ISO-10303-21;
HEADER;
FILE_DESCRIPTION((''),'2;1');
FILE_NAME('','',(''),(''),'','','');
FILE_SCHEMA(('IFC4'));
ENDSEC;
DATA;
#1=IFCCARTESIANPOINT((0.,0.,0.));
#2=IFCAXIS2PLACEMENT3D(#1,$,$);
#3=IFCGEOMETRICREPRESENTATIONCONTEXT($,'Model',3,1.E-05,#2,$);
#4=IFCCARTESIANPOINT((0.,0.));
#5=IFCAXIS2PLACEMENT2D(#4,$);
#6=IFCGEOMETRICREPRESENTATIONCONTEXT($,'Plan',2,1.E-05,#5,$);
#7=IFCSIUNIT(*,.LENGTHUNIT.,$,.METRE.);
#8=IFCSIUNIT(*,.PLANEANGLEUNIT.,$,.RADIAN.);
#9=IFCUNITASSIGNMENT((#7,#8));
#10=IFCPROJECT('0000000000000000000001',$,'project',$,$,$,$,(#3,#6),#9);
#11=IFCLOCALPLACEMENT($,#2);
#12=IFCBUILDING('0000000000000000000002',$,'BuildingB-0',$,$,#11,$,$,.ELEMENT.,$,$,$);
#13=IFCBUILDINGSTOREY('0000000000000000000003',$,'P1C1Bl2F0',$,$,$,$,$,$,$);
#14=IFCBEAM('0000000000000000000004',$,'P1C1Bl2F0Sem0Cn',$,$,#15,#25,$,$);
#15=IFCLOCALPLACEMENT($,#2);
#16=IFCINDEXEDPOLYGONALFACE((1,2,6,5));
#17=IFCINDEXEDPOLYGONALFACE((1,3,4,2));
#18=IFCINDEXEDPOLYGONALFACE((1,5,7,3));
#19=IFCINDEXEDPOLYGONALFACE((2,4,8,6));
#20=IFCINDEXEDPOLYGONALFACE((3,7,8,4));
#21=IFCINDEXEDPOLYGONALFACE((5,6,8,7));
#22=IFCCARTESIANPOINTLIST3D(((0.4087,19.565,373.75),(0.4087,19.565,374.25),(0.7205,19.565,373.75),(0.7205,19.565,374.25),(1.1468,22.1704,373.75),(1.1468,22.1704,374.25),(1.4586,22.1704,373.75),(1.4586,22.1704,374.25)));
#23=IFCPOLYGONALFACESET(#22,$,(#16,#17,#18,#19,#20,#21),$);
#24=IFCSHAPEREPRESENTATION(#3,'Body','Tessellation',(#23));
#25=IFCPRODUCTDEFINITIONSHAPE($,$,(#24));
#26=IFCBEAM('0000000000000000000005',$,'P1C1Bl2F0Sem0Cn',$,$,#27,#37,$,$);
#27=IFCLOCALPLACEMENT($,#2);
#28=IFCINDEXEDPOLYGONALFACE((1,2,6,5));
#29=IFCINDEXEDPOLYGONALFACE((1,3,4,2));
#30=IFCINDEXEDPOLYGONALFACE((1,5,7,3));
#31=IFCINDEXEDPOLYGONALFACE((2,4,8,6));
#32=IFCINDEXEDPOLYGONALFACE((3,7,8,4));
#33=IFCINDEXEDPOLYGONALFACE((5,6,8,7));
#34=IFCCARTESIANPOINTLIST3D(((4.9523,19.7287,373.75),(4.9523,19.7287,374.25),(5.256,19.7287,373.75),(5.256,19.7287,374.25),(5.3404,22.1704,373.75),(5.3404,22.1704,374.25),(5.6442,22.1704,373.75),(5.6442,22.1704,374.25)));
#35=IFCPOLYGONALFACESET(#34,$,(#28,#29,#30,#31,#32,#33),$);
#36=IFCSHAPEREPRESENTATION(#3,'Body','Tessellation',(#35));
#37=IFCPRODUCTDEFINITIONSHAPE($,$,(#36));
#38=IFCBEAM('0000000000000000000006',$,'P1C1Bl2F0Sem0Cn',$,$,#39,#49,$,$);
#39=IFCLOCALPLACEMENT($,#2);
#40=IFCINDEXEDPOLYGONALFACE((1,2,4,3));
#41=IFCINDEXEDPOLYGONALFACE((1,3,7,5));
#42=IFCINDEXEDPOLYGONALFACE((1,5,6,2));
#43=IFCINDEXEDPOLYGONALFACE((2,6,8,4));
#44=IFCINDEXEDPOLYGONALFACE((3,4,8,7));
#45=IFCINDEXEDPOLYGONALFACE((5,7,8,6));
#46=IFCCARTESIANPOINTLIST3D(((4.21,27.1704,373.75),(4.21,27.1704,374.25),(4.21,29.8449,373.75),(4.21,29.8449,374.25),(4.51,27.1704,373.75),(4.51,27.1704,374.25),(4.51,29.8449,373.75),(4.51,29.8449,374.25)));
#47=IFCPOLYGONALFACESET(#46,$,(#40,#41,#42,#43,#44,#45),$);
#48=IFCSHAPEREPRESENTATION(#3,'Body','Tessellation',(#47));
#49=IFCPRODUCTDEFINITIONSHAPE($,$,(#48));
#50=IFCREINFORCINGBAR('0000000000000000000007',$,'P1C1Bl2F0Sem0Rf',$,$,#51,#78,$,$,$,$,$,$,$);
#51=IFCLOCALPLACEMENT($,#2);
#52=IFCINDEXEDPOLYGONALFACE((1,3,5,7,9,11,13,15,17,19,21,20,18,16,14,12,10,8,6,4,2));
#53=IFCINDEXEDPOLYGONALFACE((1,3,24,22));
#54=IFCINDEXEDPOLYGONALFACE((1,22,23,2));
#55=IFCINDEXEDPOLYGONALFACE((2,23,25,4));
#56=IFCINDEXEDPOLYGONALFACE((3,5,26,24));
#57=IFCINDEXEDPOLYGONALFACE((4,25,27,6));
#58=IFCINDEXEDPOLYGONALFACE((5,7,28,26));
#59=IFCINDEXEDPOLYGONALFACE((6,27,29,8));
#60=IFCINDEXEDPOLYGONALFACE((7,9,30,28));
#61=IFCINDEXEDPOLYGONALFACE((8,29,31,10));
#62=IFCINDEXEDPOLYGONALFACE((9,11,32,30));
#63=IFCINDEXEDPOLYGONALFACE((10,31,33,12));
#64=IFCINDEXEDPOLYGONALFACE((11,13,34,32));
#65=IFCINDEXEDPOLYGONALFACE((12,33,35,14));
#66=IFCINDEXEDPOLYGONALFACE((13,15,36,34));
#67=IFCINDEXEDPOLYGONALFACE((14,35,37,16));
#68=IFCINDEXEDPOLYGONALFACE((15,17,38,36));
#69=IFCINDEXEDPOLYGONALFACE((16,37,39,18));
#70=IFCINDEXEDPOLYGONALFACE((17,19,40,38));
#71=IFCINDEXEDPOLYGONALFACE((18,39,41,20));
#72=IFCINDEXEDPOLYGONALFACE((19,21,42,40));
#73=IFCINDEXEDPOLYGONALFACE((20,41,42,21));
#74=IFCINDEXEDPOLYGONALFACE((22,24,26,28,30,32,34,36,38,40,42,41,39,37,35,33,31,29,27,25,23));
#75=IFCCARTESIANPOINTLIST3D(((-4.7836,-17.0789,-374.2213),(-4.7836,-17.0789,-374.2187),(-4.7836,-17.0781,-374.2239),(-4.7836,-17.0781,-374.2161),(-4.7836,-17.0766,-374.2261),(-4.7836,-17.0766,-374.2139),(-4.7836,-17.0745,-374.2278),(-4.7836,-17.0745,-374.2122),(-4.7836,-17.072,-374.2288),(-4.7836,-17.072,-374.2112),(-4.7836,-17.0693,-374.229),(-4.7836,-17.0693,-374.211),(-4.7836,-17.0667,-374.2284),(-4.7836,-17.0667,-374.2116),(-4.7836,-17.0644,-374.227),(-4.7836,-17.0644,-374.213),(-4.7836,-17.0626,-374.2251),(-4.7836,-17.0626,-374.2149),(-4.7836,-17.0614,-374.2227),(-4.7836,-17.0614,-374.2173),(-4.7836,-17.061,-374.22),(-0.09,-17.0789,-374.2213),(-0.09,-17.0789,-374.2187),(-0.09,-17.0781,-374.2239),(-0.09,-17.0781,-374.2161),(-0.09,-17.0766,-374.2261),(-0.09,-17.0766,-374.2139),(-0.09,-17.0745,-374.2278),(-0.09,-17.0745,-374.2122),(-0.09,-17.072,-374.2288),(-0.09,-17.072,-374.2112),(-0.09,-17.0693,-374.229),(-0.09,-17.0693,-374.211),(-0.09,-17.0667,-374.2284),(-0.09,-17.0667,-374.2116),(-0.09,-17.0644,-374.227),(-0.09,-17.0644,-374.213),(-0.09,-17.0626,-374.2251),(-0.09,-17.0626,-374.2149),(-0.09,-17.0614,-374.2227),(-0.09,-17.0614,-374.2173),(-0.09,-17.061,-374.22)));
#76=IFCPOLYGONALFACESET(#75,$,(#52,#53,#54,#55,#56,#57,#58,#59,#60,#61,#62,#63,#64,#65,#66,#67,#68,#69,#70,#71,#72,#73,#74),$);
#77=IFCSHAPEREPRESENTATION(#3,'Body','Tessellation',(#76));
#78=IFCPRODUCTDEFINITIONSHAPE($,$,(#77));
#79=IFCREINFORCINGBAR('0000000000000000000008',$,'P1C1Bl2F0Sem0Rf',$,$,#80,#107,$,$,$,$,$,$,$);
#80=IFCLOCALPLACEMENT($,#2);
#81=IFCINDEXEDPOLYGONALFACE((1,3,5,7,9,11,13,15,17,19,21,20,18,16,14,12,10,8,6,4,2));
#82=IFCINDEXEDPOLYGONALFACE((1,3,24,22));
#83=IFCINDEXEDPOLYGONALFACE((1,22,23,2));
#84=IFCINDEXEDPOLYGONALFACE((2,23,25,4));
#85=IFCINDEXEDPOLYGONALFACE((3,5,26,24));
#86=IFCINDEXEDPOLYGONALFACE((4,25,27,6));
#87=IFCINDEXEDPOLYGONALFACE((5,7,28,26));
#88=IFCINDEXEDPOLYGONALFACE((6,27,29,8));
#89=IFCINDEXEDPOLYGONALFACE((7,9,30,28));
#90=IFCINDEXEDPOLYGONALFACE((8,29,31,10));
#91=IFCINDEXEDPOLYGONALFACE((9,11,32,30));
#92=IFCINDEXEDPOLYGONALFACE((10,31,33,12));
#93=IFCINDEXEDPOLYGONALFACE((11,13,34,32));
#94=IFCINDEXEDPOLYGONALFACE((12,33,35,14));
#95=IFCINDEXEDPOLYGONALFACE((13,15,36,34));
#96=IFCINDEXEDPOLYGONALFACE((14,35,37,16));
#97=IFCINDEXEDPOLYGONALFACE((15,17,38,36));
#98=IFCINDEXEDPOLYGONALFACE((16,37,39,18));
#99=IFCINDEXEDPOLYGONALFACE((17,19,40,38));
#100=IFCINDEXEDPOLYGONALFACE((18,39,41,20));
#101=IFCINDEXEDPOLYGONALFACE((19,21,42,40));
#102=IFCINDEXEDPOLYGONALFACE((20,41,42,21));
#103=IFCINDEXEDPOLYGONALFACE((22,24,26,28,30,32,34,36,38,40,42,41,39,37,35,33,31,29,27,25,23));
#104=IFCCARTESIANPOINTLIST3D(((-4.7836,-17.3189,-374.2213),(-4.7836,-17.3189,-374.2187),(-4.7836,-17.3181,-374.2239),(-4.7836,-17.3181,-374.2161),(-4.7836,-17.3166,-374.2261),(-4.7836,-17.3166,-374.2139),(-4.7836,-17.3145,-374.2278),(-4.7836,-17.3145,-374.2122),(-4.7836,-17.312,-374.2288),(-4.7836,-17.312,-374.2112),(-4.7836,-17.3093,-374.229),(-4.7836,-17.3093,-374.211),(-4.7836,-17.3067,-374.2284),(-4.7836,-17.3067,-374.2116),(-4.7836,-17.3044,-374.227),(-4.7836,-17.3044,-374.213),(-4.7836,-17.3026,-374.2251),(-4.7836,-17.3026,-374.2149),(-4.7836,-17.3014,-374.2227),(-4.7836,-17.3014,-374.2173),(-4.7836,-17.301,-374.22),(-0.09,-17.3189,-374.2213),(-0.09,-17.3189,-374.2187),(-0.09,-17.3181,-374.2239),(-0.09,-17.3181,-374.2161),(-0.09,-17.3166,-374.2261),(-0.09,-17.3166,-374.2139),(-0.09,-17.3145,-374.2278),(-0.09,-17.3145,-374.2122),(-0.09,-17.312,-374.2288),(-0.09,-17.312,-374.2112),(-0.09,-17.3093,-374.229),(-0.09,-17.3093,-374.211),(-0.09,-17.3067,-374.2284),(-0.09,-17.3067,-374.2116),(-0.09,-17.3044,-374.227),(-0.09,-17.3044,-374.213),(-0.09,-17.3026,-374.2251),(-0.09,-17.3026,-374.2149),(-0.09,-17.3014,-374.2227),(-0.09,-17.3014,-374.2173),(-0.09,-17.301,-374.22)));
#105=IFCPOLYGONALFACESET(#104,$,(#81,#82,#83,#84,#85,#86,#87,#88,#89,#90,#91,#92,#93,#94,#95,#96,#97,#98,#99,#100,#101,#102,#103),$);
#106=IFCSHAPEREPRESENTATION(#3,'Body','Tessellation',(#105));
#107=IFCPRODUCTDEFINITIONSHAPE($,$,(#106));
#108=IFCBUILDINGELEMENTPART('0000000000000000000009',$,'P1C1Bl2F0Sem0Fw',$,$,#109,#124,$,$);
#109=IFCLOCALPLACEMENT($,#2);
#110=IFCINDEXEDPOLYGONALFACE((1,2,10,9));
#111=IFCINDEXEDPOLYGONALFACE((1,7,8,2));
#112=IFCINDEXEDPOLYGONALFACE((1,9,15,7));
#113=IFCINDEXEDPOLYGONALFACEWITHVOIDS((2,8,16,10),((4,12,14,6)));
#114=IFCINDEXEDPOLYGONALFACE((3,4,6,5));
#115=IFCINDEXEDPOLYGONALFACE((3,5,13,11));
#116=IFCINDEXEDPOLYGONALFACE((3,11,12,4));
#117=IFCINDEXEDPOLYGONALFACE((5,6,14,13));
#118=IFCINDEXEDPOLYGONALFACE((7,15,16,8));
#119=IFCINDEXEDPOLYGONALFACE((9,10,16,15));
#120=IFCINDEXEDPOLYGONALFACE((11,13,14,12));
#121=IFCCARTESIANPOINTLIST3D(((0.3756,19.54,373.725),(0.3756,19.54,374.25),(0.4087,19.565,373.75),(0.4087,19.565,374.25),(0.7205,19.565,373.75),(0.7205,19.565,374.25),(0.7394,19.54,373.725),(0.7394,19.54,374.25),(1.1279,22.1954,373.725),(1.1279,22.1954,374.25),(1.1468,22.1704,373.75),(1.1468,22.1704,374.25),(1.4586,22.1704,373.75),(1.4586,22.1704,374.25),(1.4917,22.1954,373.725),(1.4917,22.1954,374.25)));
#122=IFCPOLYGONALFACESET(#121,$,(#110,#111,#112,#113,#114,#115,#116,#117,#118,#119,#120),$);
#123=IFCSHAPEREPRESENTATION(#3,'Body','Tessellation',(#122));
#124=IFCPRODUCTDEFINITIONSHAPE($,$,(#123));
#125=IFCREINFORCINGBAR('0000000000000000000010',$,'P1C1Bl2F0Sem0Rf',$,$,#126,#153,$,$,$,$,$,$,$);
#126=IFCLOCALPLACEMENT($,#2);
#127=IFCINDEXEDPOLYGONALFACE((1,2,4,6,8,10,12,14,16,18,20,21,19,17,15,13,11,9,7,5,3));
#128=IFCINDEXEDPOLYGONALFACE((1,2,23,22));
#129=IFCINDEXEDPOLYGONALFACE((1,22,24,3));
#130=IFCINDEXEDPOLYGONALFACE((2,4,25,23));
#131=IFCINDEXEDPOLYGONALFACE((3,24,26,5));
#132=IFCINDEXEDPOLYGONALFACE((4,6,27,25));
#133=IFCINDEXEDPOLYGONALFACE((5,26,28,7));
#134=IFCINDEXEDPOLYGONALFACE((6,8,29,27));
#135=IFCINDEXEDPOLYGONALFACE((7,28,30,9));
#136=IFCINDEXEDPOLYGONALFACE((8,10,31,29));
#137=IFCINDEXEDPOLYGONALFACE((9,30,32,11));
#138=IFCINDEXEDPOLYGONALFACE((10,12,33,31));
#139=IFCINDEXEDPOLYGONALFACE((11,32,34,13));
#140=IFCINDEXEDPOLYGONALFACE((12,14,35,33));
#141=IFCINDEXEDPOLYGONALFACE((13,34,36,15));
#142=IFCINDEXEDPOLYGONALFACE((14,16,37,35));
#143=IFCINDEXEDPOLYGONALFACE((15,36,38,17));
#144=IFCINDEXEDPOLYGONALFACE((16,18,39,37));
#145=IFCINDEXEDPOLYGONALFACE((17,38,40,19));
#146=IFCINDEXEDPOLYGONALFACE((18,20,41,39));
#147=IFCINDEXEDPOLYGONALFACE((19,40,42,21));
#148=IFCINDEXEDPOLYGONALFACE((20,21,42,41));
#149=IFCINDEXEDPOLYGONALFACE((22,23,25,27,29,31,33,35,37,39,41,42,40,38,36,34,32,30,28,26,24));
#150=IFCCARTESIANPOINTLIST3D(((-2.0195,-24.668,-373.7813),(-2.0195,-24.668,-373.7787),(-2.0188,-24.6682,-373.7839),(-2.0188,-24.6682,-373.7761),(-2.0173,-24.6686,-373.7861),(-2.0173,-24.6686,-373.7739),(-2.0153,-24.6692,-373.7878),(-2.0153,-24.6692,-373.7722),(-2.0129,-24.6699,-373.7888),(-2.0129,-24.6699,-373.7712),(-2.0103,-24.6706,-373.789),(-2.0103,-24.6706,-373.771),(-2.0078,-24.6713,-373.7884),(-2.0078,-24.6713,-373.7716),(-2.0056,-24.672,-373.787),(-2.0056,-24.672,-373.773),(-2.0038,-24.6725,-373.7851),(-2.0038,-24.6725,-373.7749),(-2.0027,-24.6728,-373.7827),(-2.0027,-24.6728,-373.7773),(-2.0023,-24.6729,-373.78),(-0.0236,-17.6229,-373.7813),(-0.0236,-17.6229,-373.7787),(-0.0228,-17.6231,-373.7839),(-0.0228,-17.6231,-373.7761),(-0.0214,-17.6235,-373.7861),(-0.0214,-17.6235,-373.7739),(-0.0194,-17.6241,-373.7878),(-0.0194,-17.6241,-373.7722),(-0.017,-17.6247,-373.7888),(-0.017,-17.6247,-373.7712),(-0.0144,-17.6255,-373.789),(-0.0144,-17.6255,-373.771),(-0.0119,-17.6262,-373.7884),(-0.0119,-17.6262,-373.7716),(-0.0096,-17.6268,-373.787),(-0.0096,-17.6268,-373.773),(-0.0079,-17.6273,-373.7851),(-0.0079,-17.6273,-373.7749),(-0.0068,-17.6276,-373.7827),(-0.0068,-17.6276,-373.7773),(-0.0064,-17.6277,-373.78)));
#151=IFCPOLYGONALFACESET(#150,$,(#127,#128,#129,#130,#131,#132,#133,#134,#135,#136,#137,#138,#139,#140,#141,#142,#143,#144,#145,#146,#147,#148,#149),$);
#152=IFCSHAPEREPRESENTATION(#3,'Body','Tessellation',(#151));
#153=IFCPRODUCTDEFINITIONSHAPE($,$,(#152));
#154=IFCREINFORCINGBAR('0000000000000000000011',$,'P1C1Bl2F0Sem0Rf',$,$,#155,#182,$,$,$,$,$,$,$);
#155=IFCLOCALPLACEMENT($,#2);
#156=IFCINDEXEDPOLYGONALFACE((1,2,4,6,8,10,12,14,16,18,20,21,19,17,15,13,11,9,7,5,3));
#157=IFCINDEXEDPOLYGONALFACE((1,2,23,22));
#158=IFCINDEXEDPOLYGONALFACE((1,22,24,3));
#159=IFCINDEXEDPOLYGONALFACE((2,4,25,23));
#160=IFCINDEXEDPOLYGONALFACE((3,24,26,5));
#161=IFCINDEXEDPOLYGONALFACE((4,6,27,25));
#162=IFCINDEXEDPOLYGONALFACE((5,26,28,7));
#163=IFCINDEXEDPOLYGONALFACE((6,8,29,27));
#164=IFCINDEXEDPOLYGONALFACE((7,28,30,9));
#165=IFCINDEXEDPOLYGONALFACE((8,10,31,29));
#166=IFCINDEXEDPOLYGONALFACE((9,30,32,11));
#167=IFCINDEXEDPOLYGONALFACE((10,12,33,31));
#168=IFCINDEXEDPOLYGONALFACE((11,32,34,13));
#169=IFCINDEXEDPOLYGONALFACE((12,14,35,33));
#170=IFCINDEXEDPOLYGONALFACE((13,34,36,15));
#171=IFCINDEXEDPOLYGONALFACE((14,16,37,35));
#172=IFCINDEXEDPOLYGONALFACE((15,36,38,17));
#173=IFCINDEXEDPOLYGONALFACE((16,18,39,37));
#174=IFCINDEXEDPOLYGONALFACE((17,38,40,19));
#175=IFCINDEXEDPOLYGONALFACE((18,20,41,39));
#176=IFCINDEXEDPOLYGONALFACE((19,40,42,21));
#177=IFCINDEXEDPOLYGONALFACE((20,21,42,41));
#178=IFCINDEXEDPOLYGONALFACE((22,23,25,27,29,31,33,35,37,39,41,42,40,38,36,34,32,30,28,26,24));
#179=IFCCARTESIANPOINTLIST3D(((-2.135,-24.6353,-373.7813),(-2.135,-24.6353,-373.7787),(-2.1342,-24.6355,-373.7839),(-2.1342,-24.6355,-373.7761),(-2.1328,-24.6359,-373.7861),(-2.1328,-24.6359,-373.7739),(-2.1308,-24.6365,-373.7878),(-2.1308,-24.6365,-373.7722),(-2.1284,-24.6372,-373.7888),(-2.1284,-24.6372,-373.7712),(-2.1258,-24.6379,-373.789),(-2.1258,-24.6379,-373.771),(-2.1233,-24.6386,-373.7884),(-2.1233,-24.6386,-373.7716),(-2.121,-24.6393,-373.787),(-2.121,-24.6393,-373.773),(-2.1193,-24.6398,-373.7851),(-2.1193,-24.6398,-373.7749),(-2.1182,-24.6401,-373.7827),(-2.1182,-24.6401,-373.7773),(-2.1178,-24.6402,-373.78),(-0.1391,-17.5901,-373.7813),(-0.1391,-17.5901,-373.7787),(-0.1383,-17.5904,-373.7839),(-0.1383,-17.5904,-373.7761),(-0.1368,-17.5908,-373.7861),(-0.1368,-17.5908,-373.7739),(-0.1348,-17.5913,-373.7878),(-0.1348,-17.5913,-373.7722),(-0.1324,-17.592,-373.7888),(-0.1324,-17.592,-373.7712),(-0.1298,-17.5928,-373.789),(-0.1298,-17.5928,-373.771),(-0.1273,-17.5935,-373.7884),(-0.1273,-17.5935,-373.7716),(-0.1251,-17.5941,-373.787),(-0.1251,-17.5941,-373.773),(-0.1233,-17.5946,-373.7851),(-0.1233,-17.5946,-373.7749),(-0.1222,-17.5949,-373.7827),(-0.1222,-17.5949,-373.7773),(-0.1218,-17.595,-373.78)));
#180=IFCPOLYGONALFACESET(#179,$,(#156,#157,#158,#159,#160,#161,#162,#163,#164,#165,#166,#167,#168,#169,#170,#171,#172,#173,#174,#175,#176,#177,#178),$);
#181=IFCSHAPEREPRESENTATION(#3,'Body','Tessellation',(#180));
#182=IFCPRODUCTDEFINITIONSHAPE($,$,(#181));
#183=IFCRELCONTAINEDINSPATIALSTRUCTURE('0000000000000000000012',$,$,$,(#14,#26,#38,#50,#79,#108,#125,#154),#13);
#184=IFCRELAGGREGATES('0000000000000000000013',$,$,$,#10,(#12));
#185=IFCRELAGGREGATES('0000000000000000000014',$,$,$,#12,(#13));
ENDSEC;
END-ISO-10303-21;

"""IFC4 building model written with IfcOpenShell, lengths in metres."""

from ifc_helpers import new_model, entity, si_unit, origin, origin_2d, place, context, project, spatial, polyline, outline, extrude, element, save


model = new_model("IFC4")

# Units and contexts
model_context = context("Model", 3, precision=1e-05, world=origin())
plan_context = context("Plan", 2, precision=1e-05, world=origin_2d())
ifc_project = project(units=[si_unit("LENGTHUNIT", "METRE"), si_unit("PLANEANGLEUNIT", "RADIAN")], contexts=[model_context, plan_context])

# Building, storey
building_placement = place(None, origin())
building = spatial("IfcBuilding", under=ifc_project, at=building_placement, Name="BuildingB-0", CompositionType="ELEMENT")
storey = spatial("IfcBuildingStorey", under=building, Name="P1C1Bl2F0")

# Beams
element("IfcBeam", 1, inside=storey, Name="P1C1Bl2F0Sem0Cn", context=model_context, shape_type="SweptSolid", body=[
    extrude(outline(polyline([(0.4087, 19.565, 373.75), (1.1468, 22.1704, 373.75), (1.4586, 22.1704, 373.75), (0.7205, 19.565, 373.75), (0.4087, 19.565, 373.75)])), None, (0.0, 0.0, 1.0), 0.5),
])
element("IfcBeam", 2, inside=storey, Name="P1C1Bl2F0Sem0Cn", context=model_context, shape_type="SweptSolid", body=[
    extrude(outline(polyline([(5.256, 19.7287, 373.75), (4.9523, 19.7287, 373.75), (5.3404, 22.1704, 373.75), (5.6442, 22.1704, 373.75), (5.256, 19.7287, 373.75)])), None, (0.0, 0.0, 1.0), 0.5),
])
element("IfcBeam", 3, inside=storey, Name="P1C1Bl2F0Sem0Cn", context=model_context, shape_type="SweptSolid", body=[
    extrude(outline(polyline([(4.51, 27.1704, 373.75), (4.21, 27.1704, 373.75), (4.21, 29.8449, 373.75), (4.51, 29.8449, 373.75), (4.51, 27.1704, 373.75)])), None, (0.0, 0.0, 1.0), 0.5),
])

# Reinforcing bars
element("IfcReinforcingBar", 4, inside=storey, Name="P1C1Bl2F0Sem0Rf", context=model_context, shape_type="SweptSolid", body=[
    entity("IfcSurfaceCurveSweptAreaSolid", entity("IfcCircleProfileDef", "AREA", None, None, 0.009), None, entity("IfcPolyline", [entity("IfcCartesianPoint", [0.09, 17.07, 374.22]), entity("IfcCartesianPoint", [4.7836, 17.07, 374.22])]), None, None, entity("IfcPlane", entity("IfcAxis2Placement3D", entity("IfcCartesianPoint", [0.09, 17.07, 374.22]), entity("IfcDirection", [0.0, 0.0, 1.0]), entity("IfcDirection", [1.0, 0.0, 0.0])))),
])
element("IfcReinforcingBar", 5, inside=storey, Name="P1C1Bl2F0Sem0Rf", context=model_context, shape_type="SweptSolid", body=[
    entity("IfcSurfaceCurveSweptAreaSolid", entity("IfcCircleProfileDef", "AREA", None, None, 0.009), None, entity("IfcPolyline", [entity("IfcCartesianPoint", [0.09, 17.31, 374.22]), entity("IfcCartesianPoint", [4.7836, 17.31, 374.22])]), None, None, entity("IfcPlane", entity("IfcAxis2Placement3D", entity("IfcCartesianPoint", [0.09, 17.31, 374.22]), entity("IfcDirection", [0.0, 0.0, 1.0]), entity("IfcDirection", [1.0, 0.0, 0.0])))),
])

# Building element part, opening
building_element_part_1 = element("IfcBuildingElementPart", 6, inside=storey, Name="P1C1Bl2F0Sem0Fw", context=model_context, shape_type="SweptSolid", body=[
    extrude(outline(polyline([(0.3756, 19.54, 373.725), (1.1279, 22.1954, 373.725), (1.4917, 22.1954, 373.725), (0.7394, 19.54, 373.725), (0.3756, 19.54, 373.725)])), None, (0.0, 0.0, 1.0), 0.525),
])
element("IfcOpeningElement", 7, inside=storey, cuts=building_element_part_1, context=model_context, shape_type="SweptSolid", body=[
    extrude(outline(polyline([(0.4087, 19.565, 373.75), (1.1468, 22.1704, 373.75), (1.4586, 22.1704, 373.75), (0.7205, 19.565, 373.75), (0.4087, 19.565, 373.75)])), None, (0.0, 0.0, 1.0), 0.5),
])

# Reinforcing bars
element("IfcReinforcingBar", 8, inside=storey, Name="P1C1Bl2F0Sem0Rf", context=model_context, shape_type="SweptSolid", body=[
    entity("IfcSurfaceCurveSweptAreaSolid", entity("IfcCircleProfileDef", "AREA", None, None, 0.009), None, entity("IfcPolyline", [entity("IfcCartesianPoint", [0.015, 17.6253, 373.78]), entity("IfcCartesianPoint", [2.011, 24.6704, 373.78])]), None, None, entity("IfcPlane", entity("IfcAxis2Placement3D", entity("IfcCartesianPoint", [0.015, 17.6253, 373.78]), entity("IfcDirection", [0.0, 0.0, 1.0]), entity("IfcDirection", [1.0, 0.0, 0.0])))),
])
element("IfcReinforcingBar", 9, inside=storey, Name="P1C1Bl2F0Sem0Rf", context=model_context, shape_type="SweptSolid", body=[
    entity("IfcSurfaceCurveSweptAreaSolid", entity("IfcCircleProfileDef", "AREA", None, None, 0.009), None, entity("IfcPolyline", [entity("IfcCartesianPoint", [0.1305, 17.5926, 373.78]), entity("IfcCartesianPoint", [2.1264, 24.6377, 373.78])]), None, None, entity("IfcPlane", entity("IfcAxis2Placement3D", entity("IfcCartesianPoint", [0.1305, 17.5926, 373.78]), entity("IfcDirection", [0.0, 0.0, 1.0]), entity("IfcDirection", [1.0, 0.0, 0.0])))),
])

save(model, "model.ifc")
